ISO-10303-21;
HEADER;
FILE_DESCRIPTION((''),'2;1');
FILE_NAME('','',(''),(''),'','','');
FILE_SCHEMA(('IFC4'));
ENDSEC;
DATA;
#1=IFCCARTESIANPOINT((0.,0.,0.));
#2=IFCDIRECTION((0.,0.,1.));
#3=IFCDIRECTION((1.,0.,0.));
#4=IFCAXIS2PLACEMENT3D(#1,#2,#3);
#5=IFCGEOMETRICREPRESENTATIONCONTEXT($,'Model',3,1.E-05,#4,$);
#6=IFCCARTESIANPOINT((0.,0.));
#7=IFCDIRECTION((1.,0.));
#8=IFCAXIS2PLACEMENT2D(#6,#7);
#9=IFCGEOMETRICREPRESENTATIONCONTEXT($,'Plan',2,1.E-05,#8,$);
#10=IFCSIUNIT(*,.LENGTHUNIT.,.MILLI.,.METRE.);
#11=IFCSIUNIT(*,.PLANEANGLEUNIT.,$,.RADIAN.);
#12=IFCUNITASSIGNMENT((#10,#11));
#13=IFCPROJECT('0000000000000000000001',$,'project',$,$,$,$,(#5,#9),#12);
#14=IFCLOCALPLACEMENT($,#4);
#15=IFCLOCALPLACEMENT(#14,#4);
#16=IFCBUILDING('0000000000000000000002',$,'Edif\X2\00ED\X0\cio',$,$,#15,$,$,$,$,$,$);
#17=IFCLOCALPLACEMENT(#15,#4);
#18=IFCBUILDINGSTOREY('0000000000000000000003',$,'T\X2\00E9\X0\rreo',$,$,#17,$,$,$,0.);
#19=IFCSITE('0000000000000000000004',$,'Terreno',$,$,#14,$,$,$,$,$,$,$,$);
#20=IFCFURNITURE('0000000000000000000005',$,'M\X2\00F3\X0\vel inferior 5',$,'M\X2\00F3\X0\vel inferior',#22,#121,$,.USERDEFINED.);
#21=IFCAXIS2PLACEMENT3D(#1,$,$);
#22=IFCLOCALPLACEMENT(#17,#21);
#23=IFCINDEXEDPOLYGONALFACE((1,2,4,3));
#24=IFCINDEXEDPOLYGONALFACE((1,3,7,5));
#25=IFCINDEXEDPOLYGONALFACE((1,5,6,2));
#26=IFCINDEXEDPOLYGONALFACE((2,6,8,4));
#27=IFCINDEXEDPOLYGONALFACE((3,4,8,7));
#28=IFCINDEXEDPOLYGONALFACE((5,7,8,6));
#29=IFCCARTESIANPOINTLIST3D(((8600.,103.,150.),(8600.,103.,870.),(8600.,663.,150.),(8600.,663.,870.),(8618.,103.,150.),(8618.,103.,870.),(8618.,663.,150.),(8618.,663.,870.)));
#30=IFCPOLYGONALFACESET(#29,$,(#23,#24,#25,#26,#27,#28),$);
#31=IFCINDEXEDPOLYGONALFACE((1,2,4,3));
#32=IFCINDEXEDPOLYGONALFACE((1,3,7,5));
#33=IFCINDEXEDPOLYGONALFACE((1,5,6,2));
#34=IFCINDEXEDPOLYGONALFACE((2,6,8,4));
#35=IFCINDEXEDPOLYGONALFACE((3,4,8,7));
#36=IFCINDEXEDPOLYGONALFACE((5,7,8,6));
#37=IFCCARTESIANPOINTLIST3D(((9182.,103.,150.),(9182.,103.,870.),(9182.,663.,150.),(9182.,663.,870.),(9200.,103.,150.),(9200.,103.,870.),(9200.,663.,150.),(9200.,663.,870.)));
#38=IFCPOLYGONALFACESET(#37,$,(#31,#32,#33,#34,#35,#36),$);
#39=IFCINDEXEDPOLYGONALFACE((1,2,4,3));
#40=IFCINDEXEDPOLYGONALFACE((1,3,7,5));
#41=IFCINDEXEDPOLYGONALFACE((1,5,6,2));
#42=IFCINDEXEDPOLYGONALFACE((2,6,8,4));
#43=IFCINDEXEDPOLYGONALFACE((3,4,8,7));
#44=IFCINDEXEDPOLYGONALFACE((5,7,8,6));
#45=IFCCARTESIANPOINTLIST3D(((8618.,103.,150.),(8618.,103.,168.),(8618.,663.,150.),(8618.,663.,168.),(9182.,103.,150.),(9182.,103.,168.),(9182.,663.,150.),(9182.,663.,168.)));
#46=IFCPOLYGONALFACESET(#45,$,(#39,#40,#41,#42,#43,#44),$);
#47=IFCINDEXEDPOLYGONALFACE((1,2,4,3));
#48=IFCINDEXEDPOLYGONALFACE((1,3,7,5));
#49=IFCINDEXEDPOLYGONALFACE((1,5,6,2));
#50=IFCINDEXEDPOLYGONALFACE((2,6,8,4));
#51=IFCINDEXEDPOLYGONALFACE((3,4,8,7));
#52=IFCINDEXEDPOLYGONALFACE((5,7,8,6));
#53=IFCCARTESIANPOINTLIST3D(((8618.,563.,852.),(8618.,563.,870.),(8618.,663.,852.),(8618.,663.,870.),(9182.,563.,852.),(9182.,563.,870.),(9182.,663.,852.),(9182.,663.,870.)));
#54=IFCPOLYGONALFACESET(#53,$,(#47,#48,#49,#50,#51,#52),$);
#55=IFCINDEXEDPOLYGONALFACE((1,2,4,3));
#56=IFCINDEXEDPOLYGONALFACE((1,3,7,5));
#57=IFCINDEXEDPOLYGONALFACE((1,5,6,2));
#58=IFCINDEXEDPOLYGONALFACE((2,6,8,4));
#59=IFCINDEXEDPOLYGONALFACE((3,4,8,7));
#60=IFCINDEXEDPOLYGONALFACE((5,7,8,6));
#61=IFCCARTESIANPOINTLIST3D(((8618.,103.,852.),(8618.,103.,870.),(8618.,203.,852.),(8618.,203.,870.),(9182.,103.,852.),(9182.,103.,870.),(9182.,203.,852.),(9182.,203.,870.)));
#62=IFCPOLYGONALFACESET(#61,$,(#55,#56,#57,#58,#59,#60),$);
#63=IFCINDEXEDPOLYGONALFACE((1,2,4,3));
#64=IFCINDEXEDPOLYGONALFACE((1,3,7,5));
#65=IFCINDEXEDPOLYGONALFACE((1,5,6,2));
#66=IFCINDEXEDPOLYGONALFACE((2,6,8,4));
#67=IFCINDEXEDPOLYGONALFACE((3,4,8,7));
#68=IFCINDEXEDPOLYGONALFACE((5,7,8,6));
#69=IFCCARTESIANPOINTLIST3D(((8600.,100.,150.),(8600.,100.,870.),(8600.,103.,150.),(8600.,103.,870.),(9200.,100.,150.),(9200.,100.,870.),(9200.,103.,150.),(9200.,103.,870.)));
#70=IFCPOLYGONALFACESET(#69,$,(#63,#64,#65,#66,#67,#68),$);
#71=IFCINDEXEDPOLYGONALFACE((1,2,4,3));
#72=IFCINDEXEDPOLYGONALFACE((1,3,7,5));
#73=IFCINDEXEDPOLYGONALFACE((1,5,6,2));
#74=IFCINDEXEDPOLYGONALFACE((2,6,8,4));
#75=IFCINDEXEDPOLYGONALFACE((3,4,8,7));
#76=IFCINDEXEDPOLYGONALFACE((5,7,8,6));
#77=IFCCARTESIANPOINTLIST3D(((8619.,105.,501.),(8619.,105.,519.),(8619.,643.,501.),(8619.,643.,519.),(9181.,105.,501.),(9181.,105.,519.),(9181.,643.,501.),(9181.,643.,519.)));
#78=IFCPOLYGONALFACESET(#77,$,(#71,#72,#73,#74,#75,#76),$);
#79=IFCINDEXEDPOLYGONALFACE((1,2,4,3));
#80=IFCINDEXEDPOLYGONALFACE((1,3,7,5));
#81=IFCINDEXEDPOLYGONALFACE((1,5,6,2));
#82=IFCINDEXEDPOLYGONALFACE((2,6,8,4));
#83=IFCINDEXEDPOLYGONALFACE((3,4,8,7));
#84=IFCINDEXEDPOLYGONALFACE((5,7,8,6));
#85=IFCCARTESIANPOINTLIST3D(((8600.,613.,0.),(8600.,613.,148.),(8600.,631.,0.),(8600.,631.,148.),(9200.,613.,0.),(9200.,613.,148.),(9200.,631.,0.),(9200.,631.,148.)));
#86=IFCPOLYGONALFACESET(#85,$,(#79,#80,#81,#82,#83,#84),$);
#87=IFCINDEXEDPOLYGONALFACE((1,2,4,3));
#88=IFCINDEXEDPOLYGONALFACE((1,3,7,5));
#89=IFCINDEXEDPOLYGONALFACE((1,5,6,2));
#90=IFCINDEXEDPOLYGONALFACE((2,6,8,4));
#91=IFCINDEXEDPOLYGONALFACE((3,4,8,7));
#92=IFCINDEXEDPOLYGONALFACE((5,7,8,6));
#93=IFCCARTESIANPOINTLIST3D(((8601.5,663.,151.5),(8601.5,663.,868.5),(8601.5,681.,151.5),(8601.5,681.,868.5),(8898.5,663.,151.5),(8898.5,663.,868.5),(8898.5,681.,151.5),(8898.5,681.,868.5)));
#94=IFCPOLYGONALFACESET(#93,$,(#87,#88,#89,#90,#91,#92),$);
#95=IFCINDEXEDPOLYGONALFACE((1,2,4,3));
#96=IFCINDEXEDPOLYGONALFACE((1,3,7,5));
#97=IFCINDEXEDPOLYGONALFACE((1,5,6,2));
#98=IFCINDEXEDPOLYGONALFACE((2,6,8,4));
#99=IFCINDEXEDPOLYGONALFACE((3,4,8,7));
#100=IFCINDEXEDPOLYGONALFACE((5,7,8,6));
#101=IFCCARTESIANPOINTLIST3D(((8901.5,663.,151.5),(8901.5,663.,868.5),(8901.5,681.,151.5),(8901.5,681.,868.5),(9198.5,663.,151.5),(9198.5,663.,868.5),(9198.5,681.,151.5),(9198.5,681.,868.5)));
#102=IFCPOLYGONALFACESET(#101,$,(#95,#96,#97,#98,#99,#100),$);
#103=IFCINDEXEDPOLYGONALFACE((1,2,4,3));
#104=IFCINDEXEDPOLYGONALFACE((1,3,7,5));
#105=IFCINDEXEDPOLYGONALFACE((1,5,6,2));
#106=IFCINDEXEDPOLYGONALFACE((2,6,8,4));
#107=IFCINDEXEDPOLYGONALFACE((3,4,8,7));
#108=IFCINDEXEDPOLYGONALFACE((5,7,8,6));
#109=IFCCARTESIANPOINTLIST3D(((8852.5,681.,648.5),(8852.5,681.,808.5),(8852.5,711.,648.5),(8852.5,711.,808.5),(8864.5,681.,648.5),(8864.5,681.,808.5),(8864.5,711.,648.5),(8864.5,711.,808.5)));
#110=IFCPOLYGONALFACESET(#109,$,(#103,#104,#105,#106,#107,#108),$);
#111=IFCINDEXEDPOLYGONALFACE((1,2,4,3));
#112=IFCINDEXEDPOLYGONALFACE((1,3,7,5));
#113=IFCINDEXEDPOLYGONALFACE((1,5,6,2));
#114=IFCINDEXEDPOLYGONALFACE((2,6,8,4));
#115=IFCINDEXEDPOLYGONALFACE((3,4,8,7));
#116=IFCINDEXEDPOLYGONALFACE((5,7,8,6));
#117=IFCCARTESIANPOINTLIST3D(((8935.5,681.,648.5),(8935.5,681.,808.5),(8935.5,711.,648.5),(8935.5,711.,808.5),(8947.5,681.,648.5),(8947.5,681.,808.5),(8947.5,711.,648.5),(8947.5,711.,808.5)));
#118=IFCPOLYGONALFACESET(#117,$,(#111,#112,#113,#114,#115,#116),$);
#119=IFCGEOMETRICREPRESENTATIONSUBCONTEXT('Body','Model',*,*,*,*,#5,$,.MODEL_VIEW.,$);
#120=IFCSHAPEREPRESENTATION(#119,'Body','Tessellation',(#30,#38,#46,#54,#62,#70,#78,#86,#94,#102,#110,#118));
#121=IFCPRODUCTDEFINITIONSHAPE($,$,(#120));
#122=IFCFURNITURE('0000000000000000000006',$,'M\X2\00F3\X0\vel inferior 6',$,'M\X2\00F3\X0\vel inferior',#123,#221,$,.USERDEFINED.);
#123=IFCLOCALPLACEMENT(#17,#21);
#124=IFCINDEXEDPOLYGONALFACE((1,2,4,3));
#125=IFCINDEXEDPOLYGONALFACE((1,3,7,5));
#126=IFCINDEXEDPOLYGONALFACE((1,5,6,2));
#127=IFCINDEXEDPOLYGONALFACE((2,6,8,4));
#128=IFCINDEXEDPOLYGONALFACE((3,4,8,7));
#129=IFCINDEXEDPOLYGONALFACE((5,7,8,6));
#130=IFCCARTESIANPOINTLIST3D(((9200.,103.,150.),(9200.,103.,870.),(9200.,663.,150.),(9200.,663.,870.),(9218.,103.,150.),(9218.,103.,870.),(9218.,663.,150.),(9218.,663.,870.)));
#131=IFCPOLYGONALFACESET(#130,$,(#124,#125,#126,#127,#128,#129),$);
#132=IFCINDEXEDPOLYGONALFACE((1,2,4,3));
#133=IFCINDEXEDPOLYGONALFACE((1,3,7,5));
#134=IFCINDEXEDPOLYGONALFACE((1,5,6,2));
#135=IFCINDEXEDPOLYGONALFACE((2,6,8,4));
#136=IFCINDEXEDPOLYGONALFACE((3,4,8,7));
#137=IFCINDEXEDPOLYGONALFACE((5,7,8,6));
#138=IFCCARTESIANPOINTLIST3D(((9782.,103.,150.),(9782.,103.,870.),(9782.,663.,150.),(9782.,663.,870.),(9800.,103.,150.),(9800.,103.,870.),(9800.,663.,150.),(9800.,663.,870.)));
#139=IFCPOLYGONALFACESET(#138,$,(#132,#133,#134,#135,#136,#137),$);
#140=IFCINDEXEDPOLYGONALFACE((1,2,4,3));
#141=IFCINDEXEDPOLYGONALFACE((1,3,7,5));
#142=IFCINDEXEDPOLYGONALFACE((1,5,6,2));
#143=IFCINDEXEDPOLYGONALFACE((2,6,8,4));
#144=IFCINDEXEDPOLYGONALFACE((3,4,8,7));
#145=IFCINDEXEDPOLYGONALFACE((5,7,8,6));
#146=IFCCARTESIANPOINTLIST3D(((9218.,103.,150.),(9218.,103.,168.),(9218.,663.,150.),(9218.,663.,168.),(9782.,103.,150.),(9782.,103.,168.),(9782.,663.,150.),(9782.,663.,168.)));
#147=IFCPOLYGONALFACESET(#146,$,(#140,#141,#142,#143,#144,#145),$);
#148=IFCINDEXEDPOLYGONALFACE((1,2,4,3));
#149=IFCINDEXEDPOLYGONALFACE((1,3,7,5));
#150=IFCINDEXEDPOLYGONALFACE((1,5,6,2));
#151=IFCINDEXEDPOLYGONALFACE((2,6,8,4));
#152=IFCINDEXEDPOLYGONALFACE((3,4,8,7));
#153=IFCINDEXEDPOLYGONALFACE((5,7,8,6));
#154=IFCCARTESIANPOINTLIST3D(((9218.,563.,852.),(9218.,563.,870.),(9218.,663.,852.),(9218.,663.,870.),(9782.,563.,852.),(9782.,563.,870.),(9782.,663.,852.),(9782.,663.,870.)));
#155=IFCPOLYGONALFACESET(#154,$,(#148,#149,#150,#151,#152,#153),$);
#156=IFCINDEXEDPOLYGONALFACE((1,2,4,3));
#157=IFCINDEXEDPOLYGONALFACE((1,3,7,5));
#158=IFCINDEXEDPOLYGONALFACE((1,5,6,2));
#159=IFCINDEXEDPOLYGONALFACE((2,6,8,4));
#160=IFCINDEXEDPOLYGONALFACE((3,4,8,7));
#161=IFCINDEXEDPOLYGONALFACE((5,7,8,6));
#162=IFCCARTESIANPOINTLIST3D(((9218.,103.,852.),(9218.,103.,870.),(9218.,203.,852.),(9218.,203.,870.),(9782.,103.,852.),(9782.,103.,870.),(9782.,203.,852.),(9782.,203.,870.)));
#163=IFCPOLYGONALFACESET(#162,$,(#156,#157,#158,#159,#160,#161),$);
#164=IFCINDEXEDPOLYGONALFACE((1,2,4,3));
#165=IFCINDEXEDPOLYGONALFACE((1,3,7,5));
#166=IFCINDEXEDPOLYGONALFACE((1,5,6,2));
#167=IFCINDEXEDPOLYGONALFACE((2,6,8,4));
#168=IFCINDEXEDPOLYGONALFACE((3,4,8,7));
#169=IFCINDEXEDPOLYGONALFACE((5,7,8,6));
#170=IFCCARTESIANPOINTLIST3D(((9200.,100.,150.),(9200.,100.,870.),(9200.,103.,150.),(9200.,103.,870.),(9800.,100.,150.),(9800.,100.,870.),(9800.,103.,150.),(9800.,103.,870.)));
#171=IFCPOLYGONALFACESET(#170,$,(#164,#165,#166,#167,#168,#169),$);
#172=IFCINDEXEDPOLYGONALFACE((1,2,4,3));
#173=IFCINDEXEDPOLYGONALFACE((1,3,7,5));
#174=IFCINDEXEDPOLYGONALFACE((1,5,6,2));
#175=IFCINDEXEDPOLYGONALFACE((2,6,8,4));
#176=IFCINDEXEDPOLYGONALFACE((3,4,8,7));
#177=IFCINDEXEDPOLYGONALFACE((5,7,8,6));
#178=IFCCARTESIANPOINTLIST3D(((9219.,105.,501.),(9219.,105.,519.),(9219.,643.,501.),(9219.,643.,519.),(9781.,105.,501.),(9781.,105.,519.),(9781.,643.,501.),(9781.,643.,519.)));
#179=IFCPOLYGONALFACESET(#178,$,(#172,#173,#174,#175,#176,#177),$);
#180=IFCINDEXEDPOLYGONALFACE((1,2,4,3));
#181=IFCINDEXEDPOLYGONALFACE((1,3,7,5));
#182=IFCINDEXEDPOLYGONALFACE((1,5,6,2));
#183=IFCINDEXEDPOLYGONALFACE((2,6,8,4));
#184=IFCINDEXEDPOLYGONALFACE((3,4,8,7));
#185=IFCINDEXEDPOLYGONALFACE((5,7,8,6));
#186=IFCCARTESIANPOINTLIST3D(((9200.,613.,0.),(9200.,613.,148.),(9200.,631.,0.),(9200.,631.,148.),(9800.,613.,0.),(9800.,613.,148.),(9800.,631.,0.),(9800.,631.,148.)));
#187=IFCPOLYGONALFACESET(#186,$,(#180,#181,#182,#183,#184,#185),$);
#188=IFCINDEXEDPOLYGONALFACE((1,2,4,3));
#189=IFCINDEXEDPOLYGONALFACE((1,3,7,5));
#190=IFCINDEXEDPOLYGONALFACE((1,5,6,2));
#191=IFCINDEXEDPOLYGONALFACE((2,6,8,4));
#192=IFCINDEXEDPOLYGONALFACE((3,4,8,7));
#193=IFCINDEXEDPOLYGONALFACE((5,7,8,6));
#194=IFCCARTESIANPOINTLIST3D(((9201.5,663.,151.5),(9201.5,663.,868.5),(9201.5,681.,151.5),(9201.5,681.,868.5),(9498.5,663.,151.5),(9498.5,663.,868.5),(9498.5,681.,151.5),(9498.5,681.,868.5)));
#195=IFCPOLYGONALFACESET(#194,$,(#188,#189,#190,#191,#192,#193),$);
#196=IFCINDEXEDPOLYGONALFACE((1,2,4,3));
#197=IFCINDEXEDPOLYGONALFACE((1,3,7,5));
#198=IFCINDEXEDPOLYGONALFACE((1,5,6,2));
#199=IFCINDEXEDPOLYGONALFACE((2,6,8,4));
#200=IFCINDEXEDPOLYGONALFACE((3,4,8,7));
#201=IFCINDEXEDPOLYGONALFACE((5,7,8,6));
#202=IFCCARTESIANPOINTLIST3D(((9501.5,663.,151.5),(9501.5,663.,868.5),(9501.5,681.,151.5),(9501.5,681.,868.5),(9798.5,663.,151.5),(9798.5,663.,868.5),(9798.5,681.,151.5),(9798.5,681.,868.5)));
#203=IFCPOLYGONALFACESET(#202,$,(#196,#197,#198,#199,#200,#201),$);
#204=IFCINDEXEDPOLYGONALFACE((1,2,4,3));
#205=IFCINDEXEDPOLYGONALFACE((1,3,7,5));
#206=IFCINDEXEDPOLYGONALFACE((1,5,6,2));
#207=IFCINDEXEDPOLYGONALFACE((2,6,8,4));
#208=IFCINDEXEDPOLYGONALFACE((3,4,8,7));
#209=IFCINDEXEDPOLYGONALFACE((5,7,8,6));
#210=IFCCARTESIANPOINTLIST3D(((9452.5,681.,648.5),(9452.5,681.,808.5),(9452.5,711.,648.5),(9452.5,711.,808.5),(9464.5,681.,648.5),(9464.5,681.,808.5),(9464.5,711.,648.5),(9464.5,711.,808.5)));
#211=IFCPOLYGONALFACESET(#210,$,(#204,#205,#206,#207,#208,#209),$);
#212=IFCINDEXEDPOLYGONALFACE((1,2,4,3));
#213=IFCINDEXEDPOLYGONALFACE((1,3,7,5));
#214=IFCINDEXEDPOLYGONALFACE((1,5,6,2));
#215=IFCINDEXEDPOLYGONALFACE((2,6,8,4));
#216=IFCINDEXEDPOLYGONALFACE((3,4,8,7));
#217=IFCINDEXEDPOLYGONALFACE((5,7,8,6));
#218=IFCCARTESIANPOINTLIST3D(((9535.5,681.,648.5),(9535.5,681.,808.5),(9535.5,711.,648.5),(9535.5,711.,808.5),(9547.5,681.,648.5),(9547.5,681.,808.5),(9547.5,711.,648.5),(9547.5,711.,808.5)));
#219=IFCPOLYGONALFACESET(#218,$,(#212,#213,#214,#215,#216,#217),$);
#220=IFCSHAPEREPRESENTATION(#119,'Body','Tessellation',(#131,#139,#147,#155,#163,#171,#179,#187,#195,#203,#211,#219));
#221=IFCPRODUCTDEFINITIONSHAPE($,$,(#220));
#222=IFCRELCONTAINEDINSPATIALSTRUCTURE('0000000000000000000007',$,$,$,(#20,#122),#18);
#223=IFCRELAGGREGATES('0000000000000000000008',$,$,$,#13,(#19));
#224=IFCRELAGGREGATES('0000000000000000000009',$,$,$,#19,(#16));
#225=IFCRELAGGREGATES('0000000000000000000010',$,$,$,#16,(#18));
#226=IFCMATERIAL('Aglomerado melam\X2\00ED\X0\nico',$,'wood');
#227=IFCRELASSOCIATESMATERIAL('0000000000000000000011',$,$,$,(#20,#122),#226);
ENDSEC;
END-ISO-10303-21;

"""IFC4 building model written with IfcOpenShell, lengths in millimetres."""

from ifc_helpers import new_model, si_unit, frame, frame_2d, origin, origin_with_axes, origin_2d_with_axis, place, context, subcontext, project, spatial, rectangle, extrude, material, element, save


model = new_model("IFC4")

# Units and contexts
model_context = context("Model", 3, precision=1e-05, world=origin_with_axes())
plan_context = context("Plan", 2, precision=1e-05, world=origin_2d_with_axis())
body_context = subcontext(model_context, "Body", "Model", "MODEL_VIEW")
ifc_project = project(units=[si_unit("LENGTHUNIT", "METRE", prefix="MILLI"), si_unit("PLANEANGLEUNIT", "RADIAN")], contexts=[model_context, plan_context])

# Site, building, storey
site_placement = place(None, origin_with_axes())
site = spatial("IfcSite", under=ifc_project, at=site_placement, Name="Terreno")
building_placement = place(site_placement, origin_with_axes())
building = spatial("IfcBuilding", under=site, at=building_placement, Name="Edifício")
storey_placement = place(building_placement, origin_with_axes())
storey = spatial("IfcBuildingStorey", under=building, at=storey_placement, Name="Térreo", Elevation=0.0)

# Furniture
ifc_material_1 = material(Name="Aglomerado melamínico", Category="wood")
furniture_1_placement = place(storey_placement, frame((8600.0, 100.0, 0.0), z_axis=(0.0, 0.0, 1.0), x_axis=(1.0, 0.0, 0.0)))
element("IfcFurniture", 1, at=furniture_1_placement, inside=storey, material=ifc_material_1, Name="Móvel inferior 5", ObjectType="Móvel inferior", PredefinedType="USERDEFINED", context=body_context, shape_type="SweptSolid", body=[
    extrude(rectangle(XDim=18.0, YDim=560.0, at=frame_2d((9.0, 283.0))), frame((0.0, 0.0, 150.0)), (0.0, 0.0, 1.0), 720.0),
    extrude(rectangle(XDim=18.0, YDim=560.0, at=frame_2d((591.0, 283.0))), frame((0.0, 0.0, 150.0)), (0.0, 0.0, 1.0), 720.0),
    extrude(rectangle(XDim=564.0, YDim=560.0, at=frame_2d((300.0, 283.0))), frame((0.0, 0.0, 150.0)), (0.0, 0.0, 1.0), 18.0),
    extrude(rectangle(XDim=564.0, YDim=100.0, at=frame_2d((300.0, 513.0))), frame((0.0, 0.0, 852.0)), (0.0, 0.0, 1.0), 18.0),
    extrude(rectangle(XDim=564.0, YDim=100.0, at=frame_2d((300.0, 53.0))), frame((0.0, 0.0, 852.0)), (0.0, 0.0, 1.0), 18.0),
    extrude(rectangle(XDim=600.0, YDim=3.0, at=frame_2d((300.0, 1.5))), frame((0.0, 0.0, 150.0)), (0.0, 0.0, 1.0), 720.0),
    extrude(rectangle(XDim=562.0, YDim=538.0, at=frame_2d((300.0, 274.0))), frame((0.0, 0.0, 501.0)), (0.0, 0.0, 1.0), 18.0),
    extrude(rectangle(XDim=600.0, YDim=18.0, at=frame_2d((300.0, 522.0))), origin(), (0.0, 0.0, 1.0), 148.0),
    extrude(rectangle(XDim=297.0, YDim=18.0, at=frame_2d((150.0, 572.0))), frame((0.0, 0.0, 151.5)), (0.0, 0.0, 1.0), 717.0),
    extrude(rectangle(XDim=297.0, YDim=18.0, at=frame_2d((450.0, 572.0))), frame((0.0, 0.0, 151.5)), (0.0, 0.0, 1.0), 717.0),
    extrude(rectangle(XDim=12.0, YDim=30.0, at=frame_2d((258.5, 596.0))), frame((0.0, 0.0, 648.5)), (0.0, 0.0, 1.0), 160.0),
    extrude(rectangle(XDim=12.0, YDim=30.0, at=frame_2d((341.5, 596.0))), frame((0.0, 0.0, 648.5)), (0.0, 0.0, 1.0), 160.0),
])
furniture_2_placement = place(storey_placement, frame((9200.0, 100.0, 0.0), z_axis=(0.0, 0.0, 1.0), x_axis=(1.0, 0.0, 0.0)))
element("IfcFurniture", 2, at=furniture_2_placement, inside=storey, material=ifc_material_1, Name="Móvel inferior 6", ObjectType="Móvel inferior", PredefinedType="USERDEFINED", context=body_context, shape_type="SweptSolid", body=[
    extrude(rectangle(XDim=18.0, YDim=560.0, at=frame_2d((9.0, 283.0))), frame((0.0, 0.0, 150.0)), (0.0, 0.0, 1.0), 720.0),
    extrude(rectangle(XDim=18.0, YDim=560.0, at=frame_2d((591.0, 283.0))), frame((0.0, 0.0, 150.0)), (0.0, 0.0, 1.0), 720.0),
    extrude(rectangle(XDim=564.0, YDim=560.0, at=frame_2d((300.0, 283.0))), frame((0.0, 0.0, 150.0)), (0.0, 0.0, 1.0), 18.0),
    extrude(rectangle(XDim=564.0, YDim=100.0, at=frame_2d((300.0, 513.0))), frame((0.0, 0.0, 852.0)), (0.0, 0.0, 1.0), 18.0),
    extrude(rectangle(XDim=564.0, YDim=100.0, at=frame_2d((300.0, 53.0))), frame((0.0, 0.0, 852.0)), (0.0, 0.0, 1.0), 18.0),
    extrude(rectangle(XDim=600.0, YDim=3.0, at=frame_2d((300.0, 1.5))), frame((0.0, 0.0, 150.0)), (0.0, 0.0, 1.0), 720.0),
    extrude(rectangle(XDim=562.0, YDim=538.0, at=frame_2d((300.0, 274.0))), frame((0.0, 0.0, 501.0)), (0.0, 0.0, 1.0), 18.0),
    extrude(rectangle(XDim=600.0, YDim=18.0, at=frame_2d((300.0, 522.0))), origin(), (0.0, 0.0, 1.0), 148.0),
    extrude(rectangle(XDim=297.0, YDim=18.0, at=frame_2d((150.0, 572.0))), frame((0.0, 0.0, 151.5)), (0.0, 0.0, 1.0), 717.0),
    extrude(rectangle(XDim=297.0, YDim=18.0, at=frame_2d((450.0, 572.0))), frame((0.0, 0.0, 151.5)), (0.0, 0.0, 1.0), 717.0),
    extrude(rectangle(XDim=12.0, YDim=30.0, at=frame_2d((258.5, 596.0))), frame((0.0, 0.0, 648.5)), (0.0, 0.0, 1.0), 160.0),
    extrude(rectangle(XDim=12.0, YDim=30.0, at=frame_2d((341.5, 596.0))), frame((0.0, 0.0, 648.5)), (0.0, 0.0, 1.0), 160.0),
])

save(model, "model.ifc")
